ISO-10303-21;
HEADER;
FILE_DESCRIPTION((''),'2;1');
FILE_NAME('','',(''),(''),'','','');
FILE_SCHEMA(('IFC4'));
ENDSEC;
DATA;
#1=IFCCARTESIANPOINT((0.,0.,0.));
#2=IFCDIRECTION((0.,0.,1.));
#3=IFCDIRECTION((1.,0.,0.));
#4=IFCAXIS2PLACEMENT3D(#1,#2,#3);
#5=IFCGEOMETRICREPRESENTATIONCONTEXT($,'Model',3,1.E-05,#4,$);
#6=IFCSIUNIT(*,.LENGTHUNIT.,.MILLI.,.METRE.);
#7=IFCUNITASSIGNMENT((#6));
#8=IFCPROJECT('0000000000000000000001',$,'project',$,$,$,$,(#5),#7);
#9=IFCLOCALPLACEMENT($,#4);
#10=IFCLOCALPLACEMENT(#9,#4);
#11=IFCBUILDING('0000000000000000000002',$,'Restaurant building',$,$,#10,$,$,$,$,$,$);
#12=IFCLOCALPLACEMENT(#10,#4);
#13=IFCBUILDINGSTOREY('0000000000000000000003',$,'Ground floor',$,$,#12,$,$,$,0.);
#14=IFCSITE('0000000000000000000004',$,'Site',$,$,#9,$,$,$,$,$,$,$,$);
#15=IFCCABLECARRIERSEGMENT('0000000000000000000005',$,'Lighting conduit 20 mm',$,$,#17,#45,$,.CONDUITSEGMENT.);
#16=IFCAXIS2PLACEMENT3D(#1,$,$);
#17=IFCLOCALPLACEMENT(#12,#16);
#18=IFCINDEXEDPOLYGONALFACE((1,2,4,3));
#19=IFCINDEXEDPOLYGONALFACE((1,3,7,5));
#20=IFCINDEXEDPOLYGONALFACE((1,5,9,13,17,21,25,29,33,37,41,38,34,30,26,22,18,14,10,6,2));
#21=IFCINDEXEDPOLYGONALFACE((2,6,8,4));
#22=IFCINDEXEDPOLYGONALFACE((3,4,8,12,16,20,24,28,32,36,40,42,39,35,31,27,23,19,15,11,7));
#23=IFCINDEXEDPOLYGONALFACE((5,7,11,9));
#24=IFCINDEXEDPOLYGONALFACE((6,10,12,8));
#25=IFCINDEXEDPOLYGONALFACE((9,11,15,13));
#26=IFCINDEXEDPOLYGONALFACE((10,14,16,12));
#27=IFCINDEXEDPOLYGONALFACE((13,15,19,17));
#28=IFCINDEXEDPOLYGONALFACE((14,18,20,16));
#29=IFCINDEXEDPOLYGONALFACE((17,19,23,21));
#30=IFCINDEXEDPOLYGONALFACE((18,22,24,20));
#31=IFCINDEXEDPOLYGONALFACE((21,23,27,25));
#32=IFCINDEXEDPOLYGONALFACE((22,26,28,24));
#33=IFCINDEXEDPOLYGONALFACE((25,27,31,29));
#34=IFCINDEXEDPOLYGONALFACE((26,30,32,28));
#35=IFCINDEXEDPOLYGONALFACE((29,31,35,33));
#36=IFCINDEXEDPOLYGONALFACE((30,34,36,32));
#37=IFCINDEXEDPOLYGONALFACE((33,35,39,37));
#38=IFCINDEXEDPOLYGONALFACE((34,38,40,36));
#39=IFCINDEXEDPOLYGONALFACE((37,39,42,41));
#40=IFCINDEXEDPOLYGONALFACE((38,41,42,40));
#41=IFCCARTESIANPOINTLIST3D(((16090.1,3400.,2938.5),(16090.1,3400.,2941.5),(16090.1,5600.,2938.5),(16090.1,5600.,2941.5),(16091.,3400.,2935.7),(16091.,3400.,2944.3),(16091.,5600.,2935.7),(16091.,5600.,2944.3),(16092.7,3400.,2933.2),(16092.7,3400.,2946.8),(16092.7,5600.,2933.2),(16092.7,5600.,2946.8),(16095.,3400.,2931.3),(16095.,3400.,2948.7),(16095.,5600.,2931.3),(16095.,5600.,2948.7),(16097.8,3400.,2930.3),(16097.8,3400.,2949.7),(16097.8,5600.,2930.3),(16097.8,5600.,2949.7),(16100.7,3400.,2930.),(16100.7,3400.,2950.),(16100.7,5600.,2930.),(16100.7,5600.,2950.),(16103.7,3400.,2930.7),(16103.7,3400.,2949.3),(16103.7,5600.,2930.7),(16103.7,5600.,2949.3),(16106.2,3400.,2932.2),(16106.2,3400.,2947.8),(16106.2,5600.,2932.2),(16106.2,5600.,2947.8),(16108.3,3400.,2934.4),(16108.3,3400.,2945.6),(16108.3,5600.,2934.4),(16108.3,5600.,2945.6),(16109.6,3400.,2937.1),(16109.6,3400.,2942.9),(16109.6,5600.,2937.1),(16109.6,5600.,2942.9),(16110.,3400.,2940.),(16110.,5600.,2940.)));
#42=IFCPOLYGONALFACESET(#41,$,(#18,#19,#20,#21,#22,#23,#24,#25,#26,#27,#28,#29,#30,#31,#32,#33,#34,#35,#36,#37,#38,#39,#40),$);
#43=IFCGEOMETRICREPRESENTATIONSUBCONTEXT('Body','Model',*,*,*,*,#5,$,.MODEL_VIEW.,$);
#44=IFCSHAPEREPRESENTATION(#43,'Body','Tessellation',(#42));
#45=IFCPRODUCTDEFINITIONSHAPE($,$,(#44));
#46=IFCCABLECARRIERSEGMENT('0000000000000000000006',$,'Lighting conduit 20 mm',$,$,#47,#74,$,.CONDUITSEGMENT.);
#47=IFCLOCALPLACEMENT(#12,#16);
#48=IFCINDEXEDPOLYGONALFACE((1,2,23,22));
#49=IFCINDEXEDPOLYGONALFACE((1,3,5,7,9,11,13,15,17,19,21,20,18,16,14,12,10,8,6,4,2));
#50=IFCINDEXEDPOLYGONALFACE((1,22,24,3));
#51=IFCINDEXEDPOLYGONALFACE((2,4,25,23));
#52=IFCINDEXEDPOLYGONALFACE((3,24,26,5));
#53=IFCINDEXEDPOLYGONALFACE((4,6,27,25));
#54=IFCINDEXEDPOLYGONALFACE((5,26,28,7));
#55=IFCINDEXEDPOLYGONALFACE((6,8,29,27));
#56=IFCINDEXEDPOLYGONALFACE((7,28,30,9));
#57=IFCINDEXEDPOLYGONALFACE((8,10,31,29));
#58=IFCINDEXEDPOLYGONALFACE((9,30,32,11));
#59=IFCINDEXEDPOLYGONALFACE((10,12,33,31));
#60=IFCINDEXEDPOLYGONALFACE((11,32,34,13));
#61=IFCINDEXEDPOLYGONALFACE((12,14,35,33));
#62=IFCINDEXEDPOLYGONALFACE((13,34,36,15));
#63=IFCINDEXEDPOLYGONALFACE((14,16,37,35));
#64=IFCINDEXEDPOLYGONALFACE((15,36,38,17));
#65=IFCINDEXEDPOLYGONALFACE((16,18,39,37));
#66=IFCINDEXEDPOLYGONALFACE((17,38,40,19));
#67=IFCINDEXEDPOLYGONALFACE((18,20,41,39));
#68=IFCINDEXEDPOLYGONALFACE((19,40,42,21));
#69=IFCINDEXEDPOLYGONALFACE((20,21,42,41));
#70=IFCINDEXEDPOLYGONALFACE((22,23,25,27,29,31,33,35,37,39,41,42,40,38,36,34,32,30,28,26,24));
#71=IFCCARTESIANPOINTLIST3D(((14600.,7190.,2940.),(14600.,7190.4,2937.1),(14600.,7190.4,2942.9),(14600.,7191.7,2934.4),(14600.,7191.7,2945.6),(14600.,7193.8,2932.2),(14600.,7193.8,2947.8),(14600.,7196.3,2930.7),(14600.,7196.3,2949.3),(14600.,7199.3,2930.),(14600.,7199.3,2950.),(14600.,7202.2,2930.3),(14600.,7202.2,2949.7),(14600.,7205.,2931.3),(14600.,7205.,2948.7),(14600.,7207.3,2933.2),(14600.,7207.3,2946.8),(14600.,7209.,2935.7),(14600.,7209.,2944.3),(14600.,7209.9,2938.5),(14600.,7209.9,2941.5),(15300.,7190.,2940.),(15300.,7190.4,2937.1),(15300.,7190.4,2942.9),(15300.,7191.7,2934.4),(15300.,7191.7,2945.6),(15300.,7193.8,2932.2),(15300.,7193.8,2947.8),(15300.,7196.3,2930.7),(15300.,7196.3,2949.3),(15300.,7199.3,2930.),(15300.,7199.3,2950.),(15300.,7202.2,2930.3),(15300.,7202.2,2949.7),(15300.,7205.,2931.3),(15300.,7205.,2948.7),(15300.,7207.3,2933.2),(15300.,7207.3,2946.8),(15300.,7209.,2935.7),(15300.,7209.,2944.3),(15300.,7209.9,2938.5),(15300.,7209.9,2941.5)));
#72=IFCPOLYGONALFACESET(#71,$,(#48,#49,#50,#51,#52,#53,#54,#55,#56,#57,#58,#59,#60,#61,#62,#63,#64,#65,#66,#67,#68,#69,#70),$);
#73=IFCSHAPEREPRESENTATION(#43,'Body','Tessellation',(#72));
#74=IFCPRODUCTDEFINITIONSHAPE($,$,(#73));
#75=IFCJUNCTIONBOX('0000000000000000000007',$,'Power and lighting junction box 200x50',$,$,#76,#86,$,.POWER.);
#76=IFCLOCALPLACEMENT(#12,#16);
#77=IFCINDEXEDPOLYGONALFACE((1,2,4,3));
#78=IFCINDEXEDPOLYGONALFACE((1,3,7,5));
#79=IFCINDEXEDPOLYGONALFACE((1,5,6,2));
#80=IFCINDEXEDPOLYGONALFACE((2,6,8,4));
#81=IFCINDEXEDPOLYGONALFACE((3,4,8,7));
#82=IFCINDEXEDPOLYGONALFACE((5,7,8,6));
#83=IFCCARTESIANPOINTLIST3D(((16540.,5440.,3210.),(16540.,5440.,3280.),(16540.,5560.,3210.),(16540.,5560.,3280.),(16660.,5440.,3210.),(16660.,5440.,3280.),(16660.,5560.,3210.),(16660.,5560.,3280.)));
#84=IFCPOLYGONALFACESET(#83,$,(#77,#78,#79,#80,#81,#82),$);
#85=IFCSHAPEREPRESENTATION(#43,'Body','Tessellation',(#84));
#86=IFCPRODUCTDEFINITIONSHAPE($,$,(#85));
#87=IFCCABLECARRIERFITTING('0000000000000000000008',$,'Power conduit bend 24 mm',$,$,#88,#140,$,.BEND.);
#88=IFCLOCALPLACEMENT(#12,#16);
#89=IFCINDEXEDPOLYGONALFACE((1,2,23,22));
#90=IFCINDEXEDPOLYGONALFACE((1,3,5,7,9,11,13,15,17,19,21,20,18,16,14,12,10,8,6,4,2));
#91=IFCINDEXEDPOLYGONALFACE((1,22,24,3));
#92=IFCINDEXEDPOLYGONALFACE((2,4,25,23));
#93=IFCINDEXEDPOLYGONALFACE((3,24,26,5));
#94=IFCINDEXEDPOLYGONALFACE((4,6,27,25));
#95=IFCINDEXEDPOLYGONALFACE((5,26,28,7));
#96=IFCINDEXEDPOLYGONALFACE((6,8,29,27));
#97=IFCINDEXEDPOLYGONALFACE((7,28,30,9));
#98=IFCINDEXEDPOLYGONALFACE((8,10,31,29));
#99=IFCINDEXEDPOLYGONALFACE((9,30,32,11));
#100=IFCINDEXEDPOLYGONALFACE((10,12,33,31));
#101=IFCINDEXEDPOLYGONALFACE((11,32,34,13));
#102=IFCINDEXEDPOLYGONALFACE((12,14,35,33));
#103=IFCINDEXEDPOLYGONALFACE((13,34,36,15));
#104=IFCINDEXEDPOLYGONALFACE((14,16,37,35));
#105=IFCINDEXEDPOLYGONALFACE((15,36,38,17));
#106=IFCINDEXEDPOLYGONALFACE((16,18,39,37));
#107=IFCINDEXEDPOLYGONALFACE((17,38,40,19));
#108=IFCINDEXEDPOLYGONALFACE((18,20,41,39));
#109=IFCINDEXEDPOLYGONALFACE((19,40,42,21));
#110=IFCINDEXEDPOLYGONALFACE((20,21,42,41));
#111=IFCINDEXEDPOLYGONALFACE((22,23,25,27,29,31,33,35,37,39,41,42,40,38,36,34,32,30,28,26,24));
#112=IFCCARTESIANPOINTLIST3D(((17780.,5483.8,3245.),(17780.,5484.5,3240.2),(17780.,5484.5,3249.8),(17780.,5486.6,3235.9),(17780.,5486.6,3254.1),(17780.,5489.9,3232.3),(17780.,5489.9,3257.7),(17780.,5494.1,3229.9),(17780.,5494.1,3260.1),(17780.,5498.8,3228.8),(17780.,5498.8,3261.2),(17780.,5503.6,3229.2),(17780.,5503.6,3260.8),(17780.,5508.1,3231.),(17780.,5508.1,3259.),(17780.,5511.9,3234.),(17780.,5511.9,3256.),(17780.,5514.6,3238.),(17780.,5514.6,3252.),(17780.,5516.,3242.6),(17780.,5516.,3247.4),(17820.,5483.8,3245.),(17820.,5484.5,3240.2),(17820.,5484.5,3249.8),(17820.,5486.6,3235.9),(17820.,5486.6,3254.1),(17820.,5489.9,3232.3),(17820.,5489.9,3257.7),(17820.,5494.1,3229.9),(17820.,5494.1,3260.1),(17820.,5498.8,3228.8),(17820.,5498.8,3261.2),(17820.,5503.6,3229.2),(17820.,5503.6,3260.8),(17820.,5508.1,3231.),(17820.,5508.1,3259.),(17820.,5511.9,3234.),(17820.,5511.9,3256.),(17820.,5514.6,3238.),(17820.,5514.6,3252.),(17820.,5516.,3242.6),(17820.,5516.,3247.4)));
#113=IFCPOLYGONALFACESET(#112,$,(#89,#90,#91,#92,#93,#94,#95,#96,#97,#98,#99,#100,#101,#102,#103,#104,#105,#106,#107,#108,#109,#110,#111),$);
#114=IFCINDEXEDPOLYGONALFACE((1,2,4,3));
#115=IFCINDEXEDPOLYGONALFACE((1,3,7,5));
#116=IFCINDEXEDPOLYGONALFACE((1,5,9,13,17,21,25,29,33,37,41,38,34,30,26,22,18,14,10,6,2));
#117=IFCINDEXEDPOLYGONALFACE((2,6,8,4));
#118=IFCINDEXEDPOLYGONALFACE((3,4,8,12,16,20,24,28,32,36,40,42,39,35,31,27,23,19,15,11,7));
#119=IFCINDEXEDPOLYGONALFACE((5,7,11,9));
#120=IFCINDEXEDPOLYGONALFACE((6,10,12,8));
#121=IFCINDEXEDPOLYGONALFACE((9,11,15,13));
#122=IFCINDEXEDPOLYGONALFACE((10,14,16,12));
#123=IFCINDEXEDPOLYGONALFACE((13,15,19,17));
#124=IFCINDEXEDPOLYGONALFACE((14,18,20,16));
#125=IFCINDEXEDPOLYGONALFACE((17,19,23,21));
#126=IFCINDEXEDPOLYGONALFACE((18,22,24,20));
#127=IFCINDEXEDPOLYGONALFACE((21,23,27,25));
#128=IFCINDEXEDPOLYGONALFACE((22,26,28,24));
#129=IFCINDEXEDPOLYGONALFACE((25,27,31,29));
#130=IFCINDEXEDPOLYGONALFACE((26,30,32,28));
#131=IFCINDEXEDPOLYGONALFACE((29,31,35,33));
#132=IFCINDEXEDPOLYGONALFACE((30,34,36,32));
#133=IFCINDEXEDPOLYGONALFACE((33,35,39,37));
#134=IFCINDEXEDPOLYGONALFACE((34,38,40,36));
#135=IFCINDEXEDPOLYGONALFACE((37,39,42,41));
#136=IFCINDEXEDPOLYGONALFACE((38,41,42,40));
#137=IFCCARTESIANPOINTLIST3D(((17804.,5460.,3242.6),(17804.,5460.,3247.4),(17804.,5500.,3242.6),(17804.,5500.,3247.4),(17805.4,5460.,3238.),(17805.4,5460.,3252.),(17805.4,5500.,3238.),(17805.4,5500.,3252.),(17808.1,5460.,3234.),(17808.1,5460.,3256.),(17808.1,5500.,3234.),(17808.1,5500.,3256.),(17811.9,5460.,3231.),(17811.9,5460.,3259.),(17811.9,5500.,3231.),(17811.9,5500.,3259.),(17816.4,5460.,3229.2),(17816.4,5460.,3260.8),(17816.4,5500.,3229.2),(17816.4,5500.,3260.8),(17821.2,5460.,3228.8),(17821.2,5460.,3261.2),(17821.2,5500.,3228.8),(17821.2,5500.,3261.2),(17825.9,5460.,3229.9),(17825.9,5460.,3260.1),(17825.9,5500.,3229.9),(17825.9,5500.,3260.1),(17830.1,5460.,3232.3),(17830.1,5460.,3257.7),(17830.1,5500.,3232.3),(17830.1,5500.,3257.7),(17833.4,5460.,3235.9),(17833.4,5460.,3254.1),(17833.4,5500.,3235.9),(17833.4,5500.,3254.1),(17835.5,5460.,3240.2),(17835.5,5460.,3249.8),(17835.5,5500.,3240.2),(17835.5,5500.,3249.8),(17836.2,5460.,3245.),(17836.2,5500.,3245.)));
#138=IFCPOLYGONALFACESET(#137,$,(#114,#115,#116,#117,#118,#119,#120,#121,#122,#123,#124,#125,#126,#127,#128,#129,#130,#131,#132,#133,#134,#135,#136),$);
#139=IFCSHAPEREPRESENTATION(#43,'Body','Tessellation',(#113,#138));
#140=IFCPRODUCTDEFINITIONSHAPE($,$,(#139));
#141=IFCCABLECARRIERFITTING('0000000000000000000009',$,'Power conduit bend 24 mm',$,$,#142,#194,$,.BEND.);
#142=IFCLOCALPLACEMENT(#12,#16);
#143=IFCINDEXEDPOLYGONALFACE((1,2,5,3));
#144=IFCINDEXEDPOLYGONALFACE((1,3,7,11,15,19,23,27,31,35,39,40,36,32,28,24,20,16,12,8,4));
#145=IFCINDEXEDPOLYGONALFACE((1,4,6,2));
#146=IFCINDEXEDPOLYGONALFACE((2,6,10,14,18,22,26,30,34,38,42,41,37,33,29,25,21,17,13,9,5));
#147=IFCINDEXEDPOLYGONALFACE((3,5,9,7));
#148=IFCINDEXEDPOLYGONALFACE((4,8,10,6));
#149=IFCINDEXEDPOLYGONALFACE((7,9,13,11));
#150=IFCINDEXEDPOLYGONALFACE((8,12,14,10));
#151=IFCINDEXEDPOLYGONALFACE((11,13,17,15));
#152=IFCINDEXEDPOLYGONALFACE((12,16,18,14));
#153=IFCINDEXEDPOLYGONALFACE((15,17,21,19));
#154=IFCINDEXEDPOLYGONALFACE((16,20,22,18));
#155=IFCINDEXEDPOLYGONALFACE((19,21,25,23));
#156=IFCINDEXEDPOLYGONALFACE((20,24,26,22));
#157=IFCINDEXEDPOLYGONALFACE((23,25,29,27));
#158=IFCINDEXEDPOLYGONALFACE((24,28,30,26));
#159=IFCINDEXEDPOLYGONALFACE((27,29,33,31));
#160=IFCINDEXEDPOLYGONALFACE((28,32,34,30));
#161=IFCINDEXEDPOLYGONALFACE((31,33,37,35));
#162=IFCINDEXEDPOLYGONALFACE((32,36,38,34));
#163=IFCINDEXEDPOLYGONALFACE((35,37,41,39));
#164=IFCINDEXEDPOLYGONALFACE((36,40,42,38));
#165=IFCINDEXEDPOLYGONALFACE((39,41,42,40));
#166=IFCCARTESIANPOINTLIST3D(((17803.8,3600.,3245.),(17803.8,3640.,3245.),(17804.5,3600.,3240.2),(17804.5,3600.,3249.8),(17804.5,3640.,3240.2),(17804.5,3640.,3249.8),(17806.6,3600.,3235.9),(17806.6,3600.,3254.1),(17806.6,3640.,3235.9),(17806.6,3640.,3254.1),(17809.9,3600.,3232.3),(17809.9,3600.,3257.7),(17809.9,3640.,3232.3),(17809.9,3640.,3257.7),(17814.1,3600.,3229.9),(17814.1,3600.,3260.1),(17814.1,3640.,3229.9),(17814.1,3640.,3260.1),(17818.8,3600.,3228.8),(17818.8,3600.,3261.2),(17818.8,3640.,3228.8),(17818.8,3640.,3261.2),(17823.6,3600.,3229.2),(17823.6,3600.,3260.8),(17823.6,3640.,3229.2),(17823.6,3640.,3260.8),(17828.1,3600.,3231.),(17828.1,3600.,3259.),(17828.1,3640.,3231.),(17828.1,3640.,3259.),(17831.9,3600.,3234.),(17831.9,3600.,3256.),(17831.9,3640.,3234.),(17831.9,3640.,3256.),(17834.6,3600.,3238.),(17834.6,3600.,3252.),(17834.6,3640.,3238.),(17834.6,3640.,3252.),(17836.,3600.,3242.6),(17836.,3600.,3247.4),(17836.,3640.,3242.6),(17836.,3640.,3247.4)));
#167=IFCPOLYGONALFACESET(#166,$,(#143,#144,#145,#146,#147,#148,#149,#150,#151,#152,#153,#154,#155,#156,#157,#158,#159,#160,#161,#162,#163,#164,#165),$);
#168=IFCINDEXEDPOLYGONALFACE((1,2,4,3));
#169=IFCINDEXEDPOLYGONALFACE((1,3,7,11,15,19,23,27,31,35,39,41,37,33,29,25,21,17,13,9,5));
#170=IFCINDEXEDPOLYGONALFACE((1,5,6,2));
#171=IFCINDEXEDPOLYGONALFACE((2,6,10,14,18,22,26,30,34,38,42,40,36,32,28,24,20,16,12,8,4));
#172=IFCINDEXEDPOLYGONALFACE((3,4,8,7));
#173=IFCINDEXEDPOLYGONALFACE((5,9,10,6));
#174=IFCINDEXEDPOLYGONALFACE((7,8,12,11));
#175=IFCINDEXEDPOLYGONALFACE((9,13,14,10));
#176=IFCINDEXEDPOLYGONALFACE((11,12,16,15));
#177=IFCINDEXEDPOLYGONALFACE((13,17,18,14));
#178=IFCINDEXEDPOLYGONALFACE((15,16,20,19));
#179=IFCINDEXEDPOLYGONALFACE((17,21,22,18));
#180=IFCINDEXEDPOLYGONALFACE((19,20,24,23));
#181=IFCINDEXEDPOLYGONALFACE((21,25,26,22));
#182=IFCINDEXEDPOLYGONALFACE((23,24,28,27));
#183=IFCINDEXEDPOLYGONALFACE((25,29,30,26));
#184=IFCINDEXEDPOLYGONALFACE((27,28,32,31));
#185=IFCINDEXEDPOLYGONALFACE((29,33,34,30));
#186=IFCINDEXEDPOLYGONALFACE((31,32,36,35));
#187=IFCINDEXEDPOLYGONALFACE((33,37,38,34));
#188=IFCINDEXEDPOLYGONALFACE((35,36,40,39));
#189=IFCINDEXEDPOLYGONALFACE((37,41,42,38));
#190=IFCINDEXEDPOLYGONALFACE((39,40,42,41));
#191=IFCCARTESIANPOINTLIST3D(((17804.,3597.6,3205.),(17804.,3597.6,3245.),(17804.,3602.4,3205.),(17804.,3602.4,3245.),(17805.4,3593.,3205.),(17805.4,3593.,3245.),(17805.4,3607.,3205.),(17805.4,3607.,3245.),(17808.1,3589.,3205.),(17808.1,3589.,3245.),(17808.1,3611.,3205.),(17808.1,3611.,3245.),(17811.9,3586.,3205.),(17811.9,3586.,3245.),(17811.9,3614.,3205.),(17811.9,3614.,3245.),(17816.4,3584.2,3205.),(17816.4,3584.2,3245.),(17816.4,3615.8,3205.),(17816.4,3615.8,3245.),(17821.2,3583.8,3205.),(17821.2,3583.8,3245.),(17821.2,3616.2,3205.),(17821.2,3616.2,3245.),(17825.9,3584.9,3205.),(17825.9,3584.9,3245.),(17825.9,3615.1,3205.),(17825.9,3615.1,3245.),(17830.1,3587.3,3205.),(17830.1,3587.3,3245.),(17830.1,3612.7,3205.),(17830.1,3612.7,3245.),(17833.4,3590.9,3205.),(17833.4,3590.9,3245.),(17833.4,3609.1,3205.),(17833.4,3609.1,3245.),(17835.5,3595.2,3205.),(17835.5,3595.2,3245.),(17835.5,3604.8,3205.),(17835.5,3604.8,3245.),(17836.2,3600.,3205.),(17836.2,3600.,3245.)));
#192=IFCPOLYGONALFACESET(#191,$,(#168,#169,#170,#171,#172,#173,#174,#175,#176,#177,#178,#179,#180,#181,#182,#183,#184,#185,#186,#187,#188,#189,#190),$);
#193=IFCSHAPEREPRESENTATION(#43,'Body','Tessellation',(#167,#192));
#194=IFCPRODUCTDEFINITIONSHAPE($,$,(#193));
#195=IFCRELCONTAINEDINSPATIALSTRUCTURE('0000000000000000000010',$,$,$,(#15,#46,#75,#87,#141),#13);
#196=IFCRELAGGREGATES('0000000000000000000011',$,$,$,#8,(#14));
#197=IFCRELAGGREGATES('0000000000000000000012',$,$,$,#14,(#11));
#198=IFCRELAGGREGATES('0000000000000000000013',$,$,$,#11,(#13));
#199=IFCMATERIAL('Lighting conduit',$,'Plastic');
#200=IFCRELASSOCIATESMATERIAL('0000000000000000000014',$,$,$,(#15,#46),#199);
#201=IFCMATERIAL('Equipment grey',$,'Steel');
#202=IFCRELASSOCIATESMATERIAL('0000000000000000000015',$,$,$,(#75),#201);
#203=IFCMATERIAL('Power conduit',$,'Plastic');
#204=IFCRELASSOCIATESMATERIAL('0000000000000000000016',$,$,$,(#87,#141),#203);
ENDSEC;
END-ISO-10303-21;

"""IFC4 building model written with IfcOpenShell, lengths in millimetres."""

from ifc_helpers import new_model, si_unit, frame, origin_with_axes, origin_2d, place, context, subcontext, project, spatial, rectangle, circle, extrude, material, element, save


model = new_model("IFC4")

# Units and contexts
model_context = context("Model", 3, precision=1e-05, world=origin_with_axes())
body_context = subcontext(model_context, "Body", "Model", "MODEL_VIEW")
ifc_project = project(units=[si_unit("LENGTHUNIT", "METRE", prefix="MILLI")], contexts=[model_context])

# Site, building, storey
site_placement = place(None, origin_with_axes())
site = spatial("IfcSite", under=ifc_project, at=site_placement, Name="Site")
building_placement = place(site_placement, origin_with_axes())
building = spatial("IfcBuilding", under=site, at=building_placement, Name="Restaurant building")
storey_placement = place(building_placement, origin_with_axes())
storey = spatial("IfcBuildingStorey", under=building, at=storey_placement, Name="Ground floor", Elevation=0.0)

# Cable carrier segments
ifc_material_1 = material(Name="Power conduit", Category="Plastic")
ifc_material_2 = material(Name="Lighting conduit", Category="Plastic")
cable_carrier_segment_1_placement = place(storey_placement, frame((16100.0, 5600.0, 2940.0)))
element("IfcCableCarrierSegment", 1, at=cable_carrier_segment_1_placement, inside=storey, material=ifc_material_2, Name="Lighting conduit 20 mm", PredefinedType="CONDUITSEGMENT", context=body_context, shape_type="SweptSolid", body=[
    extrude(circle(Radius=10.0, at=origin_2d()), frame((0.0, 0.0, 0.0), z_axis=(0.0, -1.0, 0.0), x_axis=(1.0, 0.0, 0.0)), (0.0, 0.0, 1.0), 2200.0),
])
cable_carrier_segment_2_placement = place(storey_placement, frame((15300.0, 7200.0, 2940.0)))
element("IfcCableCarrierSegment", 2, at=cable_carrier_segment_2_placement, inside=storey, material=ifc_material_2, Name="Lighting conduit 20 mm", PredefinedType="CONDUITSEGMENT", context=body_context, shape_type="SweptSolid", body=[
    extrude(circle(Radius=10.0, at=origin_2d()), frame((0.0, 0.0, 0.0), z_axis=(-1.0, 0.0, 0.0), x_axis=(0.0, -1.0, 0.0)), (0.0, 0.0, 1.0), 700.0),
])

# Junction box
ifc_material_3 = material(Name="Equipment grey", Category="Steel")
junction_box_placement = place(storey_placement, frame((16600.0, 5500.0, 3245.0)))
element("IfcJunctionBox", 3, at=junction_box_placement, inside=storey, material=ifc_material_3, Name="Power and lighting junction box 200x50", PredefinedType="POWER", context=body_context, shape_type="SweptSolid", body=[
    extrude(rectangle(XDim=120.0, YDim=120.0, at=origin_2d()), frame((0.0, 0.0, -35.0)), (0.0, 0.0, 1.0), 70.0),
])

# Cable carrier fittings
cable_carrier_fitting_1_placement = place(storey_placement, frame((17820.0, 5500.0, 3245.0)))
element("IfcCableCarrierFitting", 4, at=cable_carrier_fitting_1_placement, inside=storey, material=ifc_material_1, Name="Power conduit bend 24 mm", PredefinedType="BEND", context=body_context, shape_type="SweptSolid", body=[
    extrude(circle(Radius=16.2, at=origin_2d()), frame((0.0, 0.0, 0.0), z_axis=(-1.0, 0.0, 0.0), x_axis=(0.0, -1.0, 0.0)), (0.0, 0.0, 1.0), 40.0),
    extrude(circle(Radius=16.2, at=origin_2d()), frame((0.0, 0.0, 0.0), z_axis=(0.0, -1.0, 0.0), x_axis=(1.0, 0.0, 0.0)), (0.0, 0.0, 1.0), 40.0),
])
for number, where, name in (
    (5, (17820.0, 3600.0, 3245.0), "Power conduit bend 24 mm"),
):
    element("IfcCableCarrierFitting", number, at=place(storey_placement, frame(where)), inside=storey, material=ifc_material_1, Name=name, PredefinedType="BEND", context=body_context, shape_type="SweptSolid", body=[
        extrude(circle(Radius=16.2, at=origin_2d()), frame((0.0, 0.0, 0.0), z_axis=(0.0, 1.0, 0.0), x_axis=(-1.0, 0.0, 0.0)), (0.0, 0.0, 1.0), 40.0),
        extrude(circle(Radius=16.2, at=origin_2d()), frame((0.0, 0.0, 0.0), z_axis=(0.0, 0.0, -1.0), x_axis=(1.0, 0.0, 0.0)), (0.0, 0.0, 1.0), 40.0),
    ])

save(model, "model.ifc")
